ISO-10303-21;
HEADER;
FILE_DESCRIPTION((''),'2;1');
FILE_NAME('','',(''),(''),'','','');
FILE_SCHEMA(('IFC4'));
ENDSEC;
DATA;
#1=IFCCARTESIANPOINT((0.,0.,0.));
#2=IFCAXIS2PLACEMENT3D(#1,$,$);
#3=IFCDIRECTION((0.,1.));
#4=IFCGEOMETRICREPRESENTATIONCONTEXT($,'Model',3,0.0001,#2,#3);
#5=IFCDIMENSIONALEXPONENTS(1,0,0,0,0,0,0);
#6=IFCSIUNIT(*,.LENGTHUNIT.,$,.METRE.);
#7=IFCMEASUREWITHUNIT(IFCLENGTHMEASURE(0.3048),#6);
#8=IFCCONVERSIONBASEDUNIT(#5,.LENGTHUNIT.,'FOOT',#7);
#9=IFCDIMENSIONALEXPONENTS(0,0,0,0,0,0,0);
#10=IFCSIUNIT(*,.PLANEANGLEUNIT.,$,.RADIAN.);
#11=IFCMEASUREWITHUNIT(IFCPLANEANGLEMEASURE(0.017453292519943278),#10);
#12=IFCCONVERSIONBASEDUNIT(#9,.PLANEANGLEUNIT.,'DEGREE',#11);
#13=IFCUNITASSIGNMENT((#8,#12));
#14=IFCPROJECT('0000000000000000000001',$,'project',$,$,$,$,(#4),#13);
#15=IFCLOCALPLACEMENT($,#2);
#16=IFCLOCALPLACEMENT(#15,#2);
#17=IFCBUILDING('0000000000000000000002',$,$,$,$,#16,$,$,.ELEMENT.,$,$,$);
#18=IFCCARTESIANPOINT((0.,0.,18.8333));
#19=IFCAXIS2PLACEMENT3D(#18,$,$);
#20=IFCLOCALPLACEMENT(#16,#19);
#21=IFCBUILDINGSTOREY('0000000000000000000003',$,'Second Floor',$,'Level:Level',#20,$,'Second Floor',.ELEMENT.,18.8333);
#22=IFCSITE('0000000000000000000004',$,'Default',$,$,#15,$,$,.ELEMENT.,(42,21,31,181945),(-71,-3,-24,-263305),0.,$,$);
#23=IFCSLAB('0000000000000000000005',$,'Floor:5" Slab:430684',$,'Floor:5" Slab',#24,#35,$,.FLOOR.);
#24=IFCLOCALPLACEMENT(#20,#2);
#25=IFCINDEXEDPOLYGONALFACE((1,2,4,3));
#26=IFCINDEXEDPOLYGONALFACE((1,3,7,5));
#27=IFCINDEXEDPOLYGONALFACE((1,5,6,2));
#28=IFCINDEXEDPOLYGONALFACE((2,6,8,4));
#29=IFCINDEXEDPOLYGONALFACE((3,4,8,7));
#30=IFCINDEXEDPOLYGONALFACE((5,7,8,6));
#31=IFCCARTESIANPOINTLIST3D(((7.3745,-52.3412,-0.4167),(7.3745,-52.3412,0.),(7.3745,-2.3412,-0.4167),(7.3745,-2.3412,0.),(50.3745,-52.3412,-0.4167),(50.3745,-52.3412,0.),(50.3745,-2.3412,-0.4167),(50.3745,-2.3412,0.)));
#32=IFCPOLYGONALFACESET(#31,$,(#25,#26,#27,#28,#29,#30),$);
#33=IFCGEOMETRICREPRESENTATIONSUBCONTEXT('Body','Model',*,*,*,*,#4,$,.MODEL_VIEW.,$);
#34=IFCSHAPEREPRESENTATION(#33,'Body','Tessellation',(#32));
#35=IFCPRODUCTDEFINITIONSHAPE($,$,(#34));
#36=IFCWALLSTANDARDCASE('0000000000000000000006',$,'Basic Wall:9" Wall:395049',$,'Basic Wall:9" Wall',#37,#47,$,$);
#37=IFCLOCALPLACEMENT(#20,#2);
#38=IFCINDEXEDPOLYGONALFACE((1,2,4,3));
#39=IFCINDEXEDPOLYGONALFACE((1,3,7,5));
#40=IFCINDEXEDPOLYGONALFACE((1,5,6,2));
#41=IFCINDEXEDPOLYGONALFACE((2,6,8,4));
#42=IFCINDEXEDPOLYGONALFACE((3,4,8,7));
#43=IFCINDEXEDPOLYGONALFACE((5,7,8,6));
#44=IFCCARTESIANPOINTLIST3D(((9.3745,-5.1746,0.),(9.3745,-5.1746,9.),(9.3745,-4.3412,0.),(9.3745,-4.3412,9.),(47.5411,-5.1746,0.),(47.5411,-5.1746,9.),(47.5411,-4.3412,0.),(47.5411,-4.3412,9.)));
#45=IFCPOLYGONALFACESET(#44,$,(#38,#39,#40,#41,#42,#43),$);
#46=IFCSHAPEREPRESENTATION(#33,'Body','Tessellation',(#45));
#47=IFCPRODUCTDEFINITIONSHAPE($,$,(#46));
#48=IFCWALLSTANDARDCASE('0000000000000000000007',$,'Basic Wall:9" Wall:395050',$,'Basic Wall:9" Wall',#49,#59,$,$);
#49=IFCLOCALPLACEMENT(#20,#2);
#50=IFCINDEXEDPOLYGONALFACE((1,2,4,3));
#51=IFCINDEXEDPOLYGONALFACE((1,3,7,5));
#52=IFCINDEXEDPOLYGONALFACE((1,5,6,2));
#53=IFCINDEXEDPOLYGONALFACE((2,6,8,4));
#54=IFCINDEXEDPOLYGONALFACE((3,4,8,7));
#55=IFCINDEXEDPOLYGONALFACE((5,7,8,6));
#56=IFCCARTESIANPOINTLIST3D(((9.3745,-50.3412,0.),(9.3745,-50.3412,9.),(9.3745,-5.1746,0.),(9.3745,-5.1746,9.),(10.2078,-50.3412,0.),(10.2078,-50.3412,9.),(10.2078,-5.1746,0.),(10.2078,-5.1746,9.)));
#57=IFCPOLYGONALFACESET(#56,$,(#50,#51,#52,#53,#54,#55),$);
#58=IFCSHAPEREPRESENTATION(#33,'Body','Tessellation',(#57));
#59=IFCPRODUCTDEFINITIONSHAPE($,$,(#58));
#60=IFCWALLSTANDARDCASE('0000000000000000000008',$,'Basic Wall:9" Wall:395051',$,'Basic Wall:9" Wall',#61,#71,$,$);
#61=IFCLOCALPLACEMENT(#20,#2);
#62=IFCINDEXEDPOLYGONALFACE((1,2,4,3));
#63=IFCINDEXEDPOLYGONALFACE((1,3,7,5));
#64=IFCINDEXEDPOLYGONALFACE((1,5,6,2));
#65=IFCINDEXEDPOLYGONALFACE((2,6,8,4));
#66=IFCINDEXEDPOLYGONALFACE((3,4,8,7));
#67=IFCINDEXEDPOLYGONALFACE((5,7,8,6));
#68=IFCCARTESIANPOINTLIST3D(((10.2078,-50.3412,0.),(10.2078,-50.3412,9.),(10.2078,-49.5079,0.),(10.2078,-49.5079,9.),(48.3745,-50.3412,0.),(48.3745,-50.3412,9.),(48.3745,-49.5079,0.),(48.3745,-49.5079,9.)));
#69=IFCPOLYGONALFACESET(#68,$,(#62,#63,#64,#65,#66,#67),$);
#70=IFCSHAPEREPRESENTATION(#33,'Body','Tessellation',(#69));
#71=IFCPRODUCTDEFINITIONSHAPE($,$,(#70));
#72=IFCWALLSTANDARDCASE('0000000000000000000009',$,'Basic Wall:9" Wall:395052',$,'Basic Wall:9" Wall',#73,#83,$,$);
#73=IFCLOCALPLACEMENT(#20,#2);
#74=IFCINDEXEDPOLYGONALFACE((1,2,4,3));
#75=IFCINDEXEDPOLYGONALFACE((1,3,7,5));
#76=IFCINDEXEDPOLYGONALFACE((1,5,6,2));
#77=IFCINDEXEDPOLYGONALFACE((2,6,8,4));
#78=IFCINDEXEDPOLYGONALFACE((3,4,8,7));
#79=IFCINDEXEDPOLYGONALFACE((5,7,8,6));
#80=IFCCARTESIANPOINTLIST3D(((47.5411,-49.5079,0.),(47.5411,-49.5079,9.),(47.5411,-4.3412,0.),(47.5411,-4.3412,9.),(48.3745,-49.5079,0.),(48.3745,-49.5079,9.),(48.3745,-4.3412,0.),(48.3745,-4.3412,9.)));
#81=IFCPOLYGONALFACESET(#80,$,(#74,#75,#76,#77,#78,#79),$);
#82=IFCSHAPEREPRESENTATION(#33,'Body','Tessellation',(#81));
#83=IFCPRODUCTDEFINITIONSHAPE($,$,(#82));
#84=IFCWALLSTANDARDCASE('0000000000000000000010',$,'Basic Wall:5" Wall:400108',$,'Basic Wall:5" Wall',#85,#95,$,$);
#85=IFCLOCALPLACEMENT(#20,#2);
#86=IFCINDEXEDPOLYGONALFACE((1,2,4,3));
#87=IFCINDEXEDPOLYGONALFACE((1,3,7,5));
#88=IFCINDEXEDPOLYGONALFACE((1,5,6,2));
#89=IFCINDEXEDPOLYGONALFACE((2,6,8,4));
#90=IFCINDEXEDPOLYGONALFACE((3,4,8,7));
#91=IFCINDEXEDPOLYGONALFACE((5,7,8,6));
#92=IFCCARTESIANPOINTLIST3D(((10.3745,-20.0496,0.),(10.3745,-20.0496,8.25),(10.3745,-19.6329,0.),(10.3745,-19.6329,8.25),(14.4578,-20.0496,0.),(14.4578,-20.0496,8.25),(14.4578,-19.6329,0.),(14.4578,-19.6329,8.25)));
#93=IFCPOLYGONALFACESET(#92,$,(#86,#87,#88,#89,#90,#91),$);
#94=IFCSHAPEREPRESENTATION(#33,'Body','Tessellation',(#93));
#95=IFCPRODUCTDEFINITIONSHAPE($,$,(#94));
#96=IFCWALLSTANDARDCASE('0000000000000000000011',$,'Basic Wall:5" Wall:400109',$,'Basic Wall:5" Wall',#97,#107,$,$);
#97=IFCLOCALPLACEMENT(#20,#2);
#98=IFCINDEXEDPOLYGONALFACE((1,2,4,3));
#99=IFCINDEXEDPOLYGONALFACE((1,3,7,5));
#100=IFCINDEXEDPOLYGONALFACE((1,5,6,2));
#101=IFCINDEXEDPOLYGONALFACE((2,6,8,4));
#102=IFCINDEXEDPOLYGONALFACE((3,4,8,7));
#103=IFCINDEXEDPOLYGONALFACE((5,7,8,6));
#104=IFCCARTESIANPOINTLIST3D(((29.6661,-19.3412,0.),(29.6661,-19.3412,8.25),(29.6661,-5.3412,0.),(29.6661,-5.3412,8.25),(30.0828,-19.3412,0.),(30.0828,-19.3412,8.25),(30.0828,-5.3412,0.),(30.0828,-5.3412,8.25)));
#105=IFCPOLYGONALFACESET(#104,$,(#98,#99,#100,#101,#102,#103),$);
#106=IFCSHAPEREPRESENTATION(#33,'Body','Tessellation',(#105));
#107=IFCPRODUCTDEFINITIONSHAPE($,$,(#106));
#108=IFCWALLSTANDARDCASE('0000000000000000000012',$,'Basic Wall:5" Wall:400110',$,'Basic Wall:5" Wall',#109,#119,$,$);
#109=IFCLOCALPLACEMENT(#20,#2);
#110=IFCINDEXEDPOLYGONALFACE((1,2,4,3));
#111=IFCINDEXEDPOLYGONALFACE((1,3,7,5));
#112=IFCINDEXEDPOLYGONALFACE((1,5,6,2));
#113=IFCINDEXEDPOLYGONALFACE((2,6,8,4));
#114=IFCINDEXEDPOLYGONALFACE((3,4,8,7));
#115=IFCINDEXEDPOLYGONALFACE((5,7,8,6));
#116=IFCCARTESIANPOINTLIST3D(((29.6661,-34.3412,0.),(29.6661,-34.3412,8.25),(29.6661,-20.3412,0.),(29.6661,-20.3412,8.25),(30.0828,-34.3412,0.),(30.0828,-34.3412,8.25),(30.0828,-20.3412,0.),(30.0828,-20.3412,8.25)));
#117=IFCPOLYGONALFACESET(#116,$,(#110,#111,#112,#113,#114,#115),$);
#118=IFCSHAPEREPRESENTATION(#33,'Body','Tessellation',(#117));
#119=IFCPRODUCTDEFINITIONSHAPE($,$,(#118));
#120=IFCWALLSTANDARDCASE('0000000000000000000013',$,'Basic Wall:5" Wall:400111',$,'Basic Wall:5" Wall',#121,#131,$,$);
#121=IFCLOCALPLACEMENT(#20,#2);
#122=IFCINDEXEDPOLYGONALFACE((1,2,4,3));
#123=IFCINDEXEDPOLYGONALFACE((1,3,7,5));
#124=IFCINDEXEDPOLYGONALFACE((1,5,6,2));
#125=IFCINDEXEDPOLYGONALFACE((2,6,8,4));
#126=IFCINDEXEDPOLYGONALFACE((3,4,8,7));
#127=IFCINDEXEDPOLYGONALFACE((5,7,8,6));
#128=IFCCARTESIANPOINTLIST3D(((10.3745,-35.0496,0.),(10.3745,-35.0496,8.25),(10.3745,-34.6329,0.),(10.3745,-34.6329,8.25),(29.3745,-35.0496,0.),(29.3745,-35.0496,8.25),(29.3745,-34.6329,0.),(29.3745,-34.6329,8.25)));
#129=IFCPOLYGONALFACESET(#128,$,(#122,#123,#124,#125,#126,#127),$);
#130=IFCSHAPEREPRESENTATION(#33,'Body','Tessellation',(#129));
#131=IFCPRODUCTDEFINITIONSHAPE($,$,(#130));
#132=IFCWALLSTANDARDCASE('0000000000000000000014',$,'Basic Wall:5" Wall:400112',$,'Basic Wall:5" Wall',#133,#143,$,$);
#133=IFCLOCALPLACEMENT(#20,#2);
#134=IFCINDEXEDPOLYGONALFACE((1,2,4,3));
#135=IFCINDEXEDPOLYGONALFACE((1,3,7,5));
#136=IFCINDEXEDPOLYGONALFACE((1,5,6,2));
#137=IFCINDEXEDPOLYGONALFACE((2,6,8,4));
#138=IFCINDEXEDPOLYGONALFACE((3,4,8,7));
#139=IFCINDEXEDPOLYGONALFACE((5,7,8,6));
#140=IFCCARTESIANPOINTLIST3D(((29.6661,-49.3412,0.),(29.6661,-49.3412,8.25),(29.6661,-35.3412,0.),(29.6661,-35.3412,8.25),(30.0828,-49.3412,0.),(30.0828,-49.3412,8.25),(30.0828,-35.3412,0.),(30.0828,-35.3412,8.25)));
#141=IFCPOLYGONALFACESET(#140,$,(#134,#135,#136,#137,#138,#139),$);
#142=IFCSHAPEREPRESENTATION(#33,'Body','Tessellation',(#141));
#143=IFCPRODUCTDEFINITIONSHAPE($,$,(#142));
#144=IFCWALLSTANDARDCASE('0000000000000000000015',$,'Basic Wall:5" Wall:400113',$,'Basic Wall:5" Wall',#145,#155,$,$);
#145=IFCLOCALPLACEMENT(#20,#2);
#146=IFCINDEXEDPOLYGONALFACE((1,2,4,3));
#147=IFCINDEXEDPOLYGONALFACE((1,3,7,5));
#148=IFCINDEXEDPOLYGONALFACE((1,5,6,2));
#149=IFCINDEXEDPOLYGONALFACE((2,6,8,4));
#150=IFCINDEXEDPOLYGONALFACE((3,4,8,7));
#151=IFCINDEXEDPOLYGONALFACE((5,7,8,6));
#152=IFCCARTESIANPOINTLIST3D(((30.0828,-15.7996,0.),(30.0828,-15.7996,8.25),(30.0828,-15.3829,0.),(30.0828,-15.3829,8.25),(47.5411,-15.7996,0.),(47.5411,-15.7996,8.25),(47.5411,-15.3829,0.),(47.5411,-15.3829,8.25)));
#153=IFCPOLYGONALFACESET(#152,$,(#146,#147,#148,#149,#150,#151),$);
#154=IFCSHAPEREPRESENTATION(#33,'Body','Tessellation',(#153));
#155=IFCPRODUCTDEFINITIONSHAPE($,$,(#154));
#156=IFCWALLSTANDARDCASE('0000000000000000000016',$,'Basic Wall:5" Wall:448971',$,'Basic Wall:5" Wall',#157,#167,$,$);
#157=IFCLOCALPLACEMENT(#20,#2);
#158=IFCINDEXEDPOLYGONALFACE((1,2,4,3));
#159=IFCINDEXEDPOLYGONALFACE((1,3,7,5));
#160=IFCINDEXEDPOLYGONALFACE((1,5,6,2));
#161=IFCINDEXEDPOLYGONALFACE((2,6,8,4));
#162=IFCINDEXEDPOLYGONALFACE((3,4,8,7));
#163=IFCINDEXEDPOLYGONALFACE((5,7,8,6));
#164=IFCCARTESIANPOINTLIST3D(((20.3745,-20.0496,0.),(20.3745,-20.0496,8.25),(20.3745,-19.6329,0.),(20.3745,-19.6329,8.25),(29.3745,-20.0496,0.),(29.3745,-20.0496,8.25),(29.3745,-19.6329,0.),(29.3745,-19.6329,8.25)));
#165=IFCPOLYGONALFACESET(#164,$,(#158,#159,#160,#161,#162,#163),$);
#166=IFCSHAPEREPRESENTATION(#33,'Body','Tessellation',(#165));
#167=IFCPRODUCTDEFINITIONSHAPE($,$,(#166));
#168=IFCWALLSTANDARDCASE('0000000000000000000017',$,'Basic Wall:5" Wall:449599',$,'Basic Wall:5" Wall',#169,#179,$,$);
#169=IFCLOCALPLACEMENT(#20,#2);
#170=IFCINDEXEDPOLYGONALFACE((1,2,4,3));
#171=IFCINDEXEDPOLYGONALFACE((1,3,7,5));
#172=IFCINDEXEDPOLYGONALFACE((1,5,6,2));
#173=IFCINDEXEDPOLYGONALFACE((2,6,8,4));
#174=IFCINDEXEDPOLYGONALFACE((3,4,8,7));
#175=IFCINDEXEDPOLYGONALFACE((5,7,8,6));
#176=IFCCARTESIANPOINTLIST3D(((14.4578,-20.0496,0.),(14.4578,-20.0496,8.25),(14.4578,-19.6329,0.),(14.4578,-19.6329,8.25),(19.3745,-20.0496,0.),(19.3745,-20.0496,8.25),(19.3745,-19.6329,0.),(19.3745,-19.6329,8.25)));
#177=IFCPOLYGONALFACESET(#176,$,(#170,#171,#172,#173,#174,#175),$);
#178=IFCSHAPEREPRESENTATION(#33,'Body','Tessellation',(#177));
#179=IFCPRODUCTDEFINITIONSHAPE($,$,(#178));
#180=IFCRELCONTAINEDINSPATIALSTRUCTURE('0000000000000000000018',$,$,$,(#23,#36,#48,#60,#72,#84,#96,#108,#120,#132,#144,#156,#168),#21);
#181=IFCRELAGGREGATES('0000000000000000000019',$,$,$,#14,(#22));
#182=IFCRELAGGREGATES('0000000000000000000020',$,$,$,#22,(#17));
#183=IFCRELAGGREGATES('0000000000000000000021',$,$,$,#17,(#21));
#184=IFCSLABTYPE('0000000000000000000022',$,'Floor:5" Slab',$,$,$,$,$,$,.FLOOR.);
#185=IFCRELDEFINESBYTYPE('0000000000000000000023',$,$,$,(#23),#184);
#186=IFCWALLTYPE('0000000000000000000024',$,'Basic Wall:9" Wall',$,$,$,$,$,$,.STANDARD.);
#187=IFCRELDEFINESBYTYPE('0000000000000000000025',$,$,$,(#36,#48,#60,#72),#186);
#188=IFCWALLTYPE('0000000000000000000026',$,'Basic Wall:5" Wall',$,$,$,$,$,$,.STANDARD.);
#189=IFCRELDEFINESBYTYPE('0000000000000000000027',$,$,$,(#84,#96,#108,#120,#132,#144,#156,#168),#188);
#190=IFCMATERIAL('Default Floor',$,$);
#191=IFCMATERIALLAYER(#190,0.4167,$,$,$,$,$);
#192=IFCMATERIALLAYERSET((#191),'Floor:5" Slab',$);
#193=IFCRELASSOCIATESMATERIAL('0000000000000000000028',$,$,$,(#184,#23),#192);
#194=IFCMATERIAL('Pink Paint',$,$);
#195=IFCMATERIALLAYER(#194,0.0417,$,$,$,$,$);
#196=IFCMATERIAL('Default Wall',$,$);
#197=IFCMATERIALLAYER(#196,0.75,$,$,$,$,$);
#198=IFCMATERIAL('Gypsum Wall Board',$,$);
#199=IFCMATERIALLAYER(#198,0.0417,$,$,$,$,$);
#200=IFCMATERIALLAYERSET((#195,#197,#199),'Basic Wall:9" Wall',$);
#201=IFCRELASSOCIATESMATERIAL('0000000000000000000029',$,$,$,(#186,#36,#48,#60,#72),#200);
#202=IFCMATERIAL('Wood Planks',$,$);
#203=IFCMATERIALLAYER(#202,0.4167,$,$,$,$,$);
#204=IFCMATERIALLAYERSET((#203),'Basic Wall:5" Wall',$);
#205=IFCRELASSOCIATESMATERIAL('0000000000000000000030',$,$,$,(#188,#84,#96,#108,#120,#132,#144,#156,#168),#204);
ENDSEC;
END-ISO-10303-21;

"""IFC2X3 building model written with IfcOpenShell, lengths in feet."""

from ifc_helpers import new_model, entity, si_unit, converted_unit, direction, frame, frame_2d, origin, origin_2d_with_axis, place, context, subcontext, project, spatial, rectangle, extrude, material, layer, layer_set, layer_usage, type_object, element, save


model = new_model("IFC2X3")

# Units and contexts
model_context = context("Model", 3, precision=0.0001, world=origin(), true_north=direction((0.0, 1.0)))
body_context = subcontext(model_context, "Body", "Model", "MODEL_VIEW")
ifc_project = project(units=[converted_unit("LENGTHUNIT", "FOOT", entity("IfcLengthMeasure", 0.3048), si_unit("LENGTHUNIT", "METRE"), dimensions=[1, 0, 0, 0, 0, 0, 0]), converted_unit("PLANEANGLEUNIT", "DEGREE", entity("IfcPlaneAngleMeasure", 0.017453292519943278), si_unit("PLANEANGLEUNIT", "RADIAN"), dimensions=[0, 0, 0, 0, 0, 0, 0])], contexts=[model_context])

# Site, building, storey
site_placement = place(None, origin())
site = spatial("IfcSite", under=ifc_project, at=site_placement, Name="Default", CompositionType="ELEMENT", RefLatitude=(42, 21, 31, 181945), RefLongitude=(-71, -3, -24, -263305), RefElevation=0.0)
building_placement = place(site_placement, origin())
building = spatial("IfcBuilding", under=site, at=building_placement, CompositionType="ELEMENT")
storey_placement = place(building_placement, frame((0.0, 0.0, 18.8333)))
storey = spatial("IfcBuildingStorey", under=building, at=storey_placement, Name="Second Floor", ObjectType="Level:Level", LongName="Second Floor", CompositionType="ELEMENT", Elevation=18.8333)

# Slab
ifc_material_1 = material(Name="Default Floor")
ifc_layer_1 = layer(ifc_material_1, 0.4167)
ifc_layer_set_1 = layer_set([ifc_layer_1], Name="Floor:5\" Slab")
ifc_layer_usage_1 = layer_usage(ifc_layer_set_1, "AXIS3", "POSITIVE", 0.0)
slab_type = type_object("IfcSlabType", Name="Floor:5\" Slab", PredefinedType="FLOOR", material=ifc_layer_set_1)
slab_placement = place(storey_placement, origin())
element("IfcSlab", 1, at=slab_placement, inside=storey, type_object=slab_type, material=ifc_layer_usage_1, Name="Floor:5\" Slab:430684", ObjectType="Floor:5\" Slab", PredefinedType="FLOOR", context=body_context, shape_type="SweptSolid", body=[
    extrude(rectangle(XDim=50.0, YDim=43.0, at=origin_2d_with_axis()), frame((28.8745, -27.3412, 0.0), z_axis=(0.0, 0.0, -1.0), x_axis=(0.0, 1.0, 0.0)), (0.0, 0.0, 1.0), 0.4167),
])

# Walls
ifc_material_2 = material(Name="Pink Paint")
ifc_layer_2 = layer(ifc_material_2, 0.0417)
ifc_material_3 = material(Name="Default Wall")
ifc_layer_3 = layer(ifc_material_3, 0.75)
ifc_material_4 = material(Name="Gypsum Wall Board")
ifc_layer_4 = layer(ifc_material_4, 0.0417)
ifc_layer_set_2 = layer_set([ifc_layer_2, ifc_layer_3, ifc_layer_4], Name="Basic Wall:9\" Wall")
ifc_layer_usage_2 = layer_usage(ifc_layer_set_2, "AXIS2", "NEGATIVE", 0.4167)
wall_type_1 = type_object("IfcWallType", Name="Basic Wall:9\" Wall", PredefinedType="STANDARD", material=ifc_layer_set_2)
wall_1_placement = place(storey_placement, frame((9.3745, -4.7579, 0.0)))
element("IfcWallStandardCase", 2, at=wall_1_placement, inside=storey, type_object=wall_type_1, material=ifc_layer_usage_2, Name="Basic Wall:9\" Wall:395049", ObjectType="Basic Wall:9\" Wall", context=body_context, shape_type="SweptSolid", body=[
    extrude(rectangle(XDim=38.1667, YDim=0.8333, at=frame_2d((19.0833, 0.0), x_axis=(-1.0, 0.0))), origin(), (0.0, 0.0, 1.0), 9.0),
])
wall_2_placement = place(storey_placement, frame((9.7911, -50.3412, 0.0), z_axis=(0.0, 0.0, 1.0), x_axis=(0.0, 1.0, 0.0)))
element("IfcWallStandardCase", 3, at=wall_2_placement, inside=storey, type_object=wall_type_1, material=ifc_layer_usage_2, Name="Basic Wall:9\" Wall:395050", ObjectType="Basic Wall:9\" Wall", context=body_context, shape_type="SweptSolid", body=[
    extrude(rectangle(XDim=45.1667, YDim=0.8333, at=frame_2d((22.5833, 0.0), x_axis=(-1.0, 0.0))), origin(), (0.0, 0.0, 1.0), 9.0),
])
wall_3_placement = place(storey_placement, frame((48.3745, -49.9246, 0.0), z_axis=(0.0, 0.0, 1.0), x_axis=(-1.0, 0.0, 0.0)))
element("IfcWallStandardCase", 4, at=wall_3_placement, inside=storey, type_object=wall_type_1, material=ifc_layer_usage_2, Name="Basic Wall:9\" Wall:395051", ObjectType="Basic Wall:9\" Wall", context=body_context, shape_type="SweptSolid", body=[
    extrude(rectangle(XDim=38.1667, YDim=0.8333, at=frame_2d((19.0833, 0.0), x_axis=(-1.0, 0.0))), origin(), (0.0, 0.0, 1.0), 9.0),
])
wall_4_placement = place(storey_placement, frame((47.9578, -4.3412, 0.0), z_axis=(0.0, 0.0, 1.0), x_axis=(0.0, -1.0, 0.0)))
element("IfcWallStandardCase", 5, at=wall_4_placement, inside=storey, type_object=wall_type_1, material=ifc_layer_usage_2, Name="Basic Wall:9\" Wall:395052", ObjectType="Basic Wall:9\" Wall", context=body_context, shape_type="SweptSolid", body=[
    extrude(rectangle(XDim=45.1667, YDim=0.8333, at=frame_2d((22.5833, 0.0), x_axis=(-1.0, 0.0))), origin(), (0.0, 0.0, 1.0), 9.0),
])
ifc_material_5 = material(Name="Wood Planks")
ifc_layer_5 = layer(ifc_material_5, 0.4167)
ifc_layer_set_3 = layer_set([ifc_layer_5], Name="Basic Wall:5\" Wall")
ifc_layer_usage_3 = layer_usage(ifc_layer_set_3, "AXIS2", "NEGATIVE", 0.2083)
wall_type_2 = type_object("IfcWallType", Name="Basic Wall:5\" Wall", PredefinedType="STANDARD", material=ifc_layer_set_3)
wall_5_placement = place(storey_placement, frame((10.3745, -19.8412, 0.0)))
element("IfcWallStandardCase", 6, at=wall_5_placement, inside=storey, type_object=wall_type_2, material=ifc_layer_usage_3, Name="Basic Wall:5\" Wall:400108", ObjectType="Basic Wall:5\" Wall", context=body_context, shape_type="SweptSolid", body=[
    extrude(rectangle(XDim=4.0833, YDim=0.4167, at=frame_2d((2.0417, 0.0), x_axis=(-1.0, 0.0))), origin(), (0.0, 0.0, 1.0), 8.25),
])
wall_6_placement = place(storey_placement, frame((29.8745, -19.3412, 0.0), z_axis=(0.0, 0.0, 1.0), x_axis=(0.0, 1.0, 0.0)))
element("IfcWallStandardCase", 7, at=wall_6_placement, inside=storey, type_object=wall_type_2, material=ifc_layer_usage_3, Name="Basic Wall:5\" Wall:400109", ObjectType="Basic Wall:5\" Wall", context=body_context, shape_type="SweptSolid", body=[
    extrude(rectangle(XDim=14.0, YDim=0.4167, at=frame_2d((7.0, 0.0), x_axis=(-1.0, 0.0))), origin(), (0.0, 0.0, 1.0), 8.25),
])
wall_7_placement = place(storey_placement, frame((29.8745, -20.3412, 0.0), z_axis=(0.0, 0.0, 1.0), x_axis=(0.0, -1.0, 0.0)))
element("IfcWallStandardCase", 8, at=wall_7_placement, inside=storey, type_object=wall_type_2, material=ifc_layer_usage_3, Name="Basic Wall:5\" Wall:400110", ObjectType="Basic Wall:5\" Wall", context=body_context, shape_type="SweptSolid", body=[
    extrude(rectangle(XDim=14.0, YDim=0.4167, at=frame_2d((7.0, 0.0), x_axis=(-1.0, 0.0))), origin(), (0.0, 0.0, 1.0), 8.25),
])
wall_8_placement = place(storey_placement, frame((29.3745, -34.8412, 0.0), z_axis=(0.0, 0.0, 1.0), x_axis=(-1.0, 0.0, 0.0)))
element("IfcWallStandardCase", 9, at=wall_8_placement, inside=storey, type_object=wall_type_2, material=ifc_layer_usage_3, Name="Basic Wall:5\" Wall:400111", ObjectType="Basic Wall:5\" Wall", context=body_context, shape_type="SweptSolid", body=[
    extrude(rectangle(XDim=19.0, YDim=0.4167, at=frame_2d((9.5, 0.0), x_axis=(-1.0, 0.0))), origin(), (0.0, 0.0, 1.0), 8.25),
])
wall_9_placement = place(storey_placement, frame((29.8745, -35.3412, 0.0), z_axis=(0.0, 0.0, 1.0), x_axis=(0.0, -1.0, 0.0)))
element("IfcWallStandardCase", 10, at=wall_9_placement, inside=storey, type_object=wall_type_2, material=ifc_layer_usage_3, Name="Basic Wall:5\" Wall:400112", ObjectType="Basic Wall:5\" Wall", context=body_context, shape_type="SweptSolid", body=[
    extrude(rectangle(XDim=14.0, YDim=0.4167, at=frame_2d((7.0, 0.0), x_axis=(-1.0, 0.0))), origin(), (0.0, 0.0, 1.0), 8.25),
])
wall_10_placement = place(storey_placement, frame((30.0828, -15.5912, 0.0)))
element("IfcWallStandardCase", 11, at=wall_10_placement, inside=storey, type_object=wall_type_2, material=ifc_layer_usage_3, Name="Basic Wall:5\" Wall:400113", ObjectType="Basic Wall:5\" Wall", context=body_context, shape_type="SweptSolid", body=[
    extrude(rectangle(XDim=17.4583, YDim=0.4167, at=frame_2d((8.7292, 0.0), x_axis=(-1.0, 0.0))), origin(), (0.0, 0.0, 1.0), 8.25),
])
wall_11_placement = place(storey_placement, frame((20.3745, -19.8412, 0.0)))
element("IfcWallStandardCase", 12, at=wall_11_placement, inside=storey, type_object=wall_type_2, material=ifc_layer_usage_3, Name="Basic Wall:5\" Wall:448971", ObjectType="Basic Wall:5\" Wall", context=body_context, shape_type="SweptSolid", body=[
    extrude(rectangle(XDim=9.0, YDim=0.4167, at=frame_2d((4.5, 0.0), x_axis=(-1.0, 0.0))), origin(), (0.0, 0.0, 1.0), 8.25),
])
wall_12_placement = place(storey_placement, frame((14.4578, -19.8412, 0.0)))
element("IfcWallStandardCase", 13, at=wall_12_placement, inside=storey, type_object=wall_type_2, material=ifc_layer_usage_3, Name="Basic Wall:5\" Wall:449599", ObjectType="Basic Wall:5\" Wall", context=body_context, shape_type="SweptSolid", body=[
    extrude(rectangle(XDim=4.9167, YDim=0.4167, at=frame_2d((2.4583, 0.0), x_axis=(-1.0, 0.0))), origin(), (0.0, 0.0, 1.0), 8.25),
])

save(model, "model.ifc")
